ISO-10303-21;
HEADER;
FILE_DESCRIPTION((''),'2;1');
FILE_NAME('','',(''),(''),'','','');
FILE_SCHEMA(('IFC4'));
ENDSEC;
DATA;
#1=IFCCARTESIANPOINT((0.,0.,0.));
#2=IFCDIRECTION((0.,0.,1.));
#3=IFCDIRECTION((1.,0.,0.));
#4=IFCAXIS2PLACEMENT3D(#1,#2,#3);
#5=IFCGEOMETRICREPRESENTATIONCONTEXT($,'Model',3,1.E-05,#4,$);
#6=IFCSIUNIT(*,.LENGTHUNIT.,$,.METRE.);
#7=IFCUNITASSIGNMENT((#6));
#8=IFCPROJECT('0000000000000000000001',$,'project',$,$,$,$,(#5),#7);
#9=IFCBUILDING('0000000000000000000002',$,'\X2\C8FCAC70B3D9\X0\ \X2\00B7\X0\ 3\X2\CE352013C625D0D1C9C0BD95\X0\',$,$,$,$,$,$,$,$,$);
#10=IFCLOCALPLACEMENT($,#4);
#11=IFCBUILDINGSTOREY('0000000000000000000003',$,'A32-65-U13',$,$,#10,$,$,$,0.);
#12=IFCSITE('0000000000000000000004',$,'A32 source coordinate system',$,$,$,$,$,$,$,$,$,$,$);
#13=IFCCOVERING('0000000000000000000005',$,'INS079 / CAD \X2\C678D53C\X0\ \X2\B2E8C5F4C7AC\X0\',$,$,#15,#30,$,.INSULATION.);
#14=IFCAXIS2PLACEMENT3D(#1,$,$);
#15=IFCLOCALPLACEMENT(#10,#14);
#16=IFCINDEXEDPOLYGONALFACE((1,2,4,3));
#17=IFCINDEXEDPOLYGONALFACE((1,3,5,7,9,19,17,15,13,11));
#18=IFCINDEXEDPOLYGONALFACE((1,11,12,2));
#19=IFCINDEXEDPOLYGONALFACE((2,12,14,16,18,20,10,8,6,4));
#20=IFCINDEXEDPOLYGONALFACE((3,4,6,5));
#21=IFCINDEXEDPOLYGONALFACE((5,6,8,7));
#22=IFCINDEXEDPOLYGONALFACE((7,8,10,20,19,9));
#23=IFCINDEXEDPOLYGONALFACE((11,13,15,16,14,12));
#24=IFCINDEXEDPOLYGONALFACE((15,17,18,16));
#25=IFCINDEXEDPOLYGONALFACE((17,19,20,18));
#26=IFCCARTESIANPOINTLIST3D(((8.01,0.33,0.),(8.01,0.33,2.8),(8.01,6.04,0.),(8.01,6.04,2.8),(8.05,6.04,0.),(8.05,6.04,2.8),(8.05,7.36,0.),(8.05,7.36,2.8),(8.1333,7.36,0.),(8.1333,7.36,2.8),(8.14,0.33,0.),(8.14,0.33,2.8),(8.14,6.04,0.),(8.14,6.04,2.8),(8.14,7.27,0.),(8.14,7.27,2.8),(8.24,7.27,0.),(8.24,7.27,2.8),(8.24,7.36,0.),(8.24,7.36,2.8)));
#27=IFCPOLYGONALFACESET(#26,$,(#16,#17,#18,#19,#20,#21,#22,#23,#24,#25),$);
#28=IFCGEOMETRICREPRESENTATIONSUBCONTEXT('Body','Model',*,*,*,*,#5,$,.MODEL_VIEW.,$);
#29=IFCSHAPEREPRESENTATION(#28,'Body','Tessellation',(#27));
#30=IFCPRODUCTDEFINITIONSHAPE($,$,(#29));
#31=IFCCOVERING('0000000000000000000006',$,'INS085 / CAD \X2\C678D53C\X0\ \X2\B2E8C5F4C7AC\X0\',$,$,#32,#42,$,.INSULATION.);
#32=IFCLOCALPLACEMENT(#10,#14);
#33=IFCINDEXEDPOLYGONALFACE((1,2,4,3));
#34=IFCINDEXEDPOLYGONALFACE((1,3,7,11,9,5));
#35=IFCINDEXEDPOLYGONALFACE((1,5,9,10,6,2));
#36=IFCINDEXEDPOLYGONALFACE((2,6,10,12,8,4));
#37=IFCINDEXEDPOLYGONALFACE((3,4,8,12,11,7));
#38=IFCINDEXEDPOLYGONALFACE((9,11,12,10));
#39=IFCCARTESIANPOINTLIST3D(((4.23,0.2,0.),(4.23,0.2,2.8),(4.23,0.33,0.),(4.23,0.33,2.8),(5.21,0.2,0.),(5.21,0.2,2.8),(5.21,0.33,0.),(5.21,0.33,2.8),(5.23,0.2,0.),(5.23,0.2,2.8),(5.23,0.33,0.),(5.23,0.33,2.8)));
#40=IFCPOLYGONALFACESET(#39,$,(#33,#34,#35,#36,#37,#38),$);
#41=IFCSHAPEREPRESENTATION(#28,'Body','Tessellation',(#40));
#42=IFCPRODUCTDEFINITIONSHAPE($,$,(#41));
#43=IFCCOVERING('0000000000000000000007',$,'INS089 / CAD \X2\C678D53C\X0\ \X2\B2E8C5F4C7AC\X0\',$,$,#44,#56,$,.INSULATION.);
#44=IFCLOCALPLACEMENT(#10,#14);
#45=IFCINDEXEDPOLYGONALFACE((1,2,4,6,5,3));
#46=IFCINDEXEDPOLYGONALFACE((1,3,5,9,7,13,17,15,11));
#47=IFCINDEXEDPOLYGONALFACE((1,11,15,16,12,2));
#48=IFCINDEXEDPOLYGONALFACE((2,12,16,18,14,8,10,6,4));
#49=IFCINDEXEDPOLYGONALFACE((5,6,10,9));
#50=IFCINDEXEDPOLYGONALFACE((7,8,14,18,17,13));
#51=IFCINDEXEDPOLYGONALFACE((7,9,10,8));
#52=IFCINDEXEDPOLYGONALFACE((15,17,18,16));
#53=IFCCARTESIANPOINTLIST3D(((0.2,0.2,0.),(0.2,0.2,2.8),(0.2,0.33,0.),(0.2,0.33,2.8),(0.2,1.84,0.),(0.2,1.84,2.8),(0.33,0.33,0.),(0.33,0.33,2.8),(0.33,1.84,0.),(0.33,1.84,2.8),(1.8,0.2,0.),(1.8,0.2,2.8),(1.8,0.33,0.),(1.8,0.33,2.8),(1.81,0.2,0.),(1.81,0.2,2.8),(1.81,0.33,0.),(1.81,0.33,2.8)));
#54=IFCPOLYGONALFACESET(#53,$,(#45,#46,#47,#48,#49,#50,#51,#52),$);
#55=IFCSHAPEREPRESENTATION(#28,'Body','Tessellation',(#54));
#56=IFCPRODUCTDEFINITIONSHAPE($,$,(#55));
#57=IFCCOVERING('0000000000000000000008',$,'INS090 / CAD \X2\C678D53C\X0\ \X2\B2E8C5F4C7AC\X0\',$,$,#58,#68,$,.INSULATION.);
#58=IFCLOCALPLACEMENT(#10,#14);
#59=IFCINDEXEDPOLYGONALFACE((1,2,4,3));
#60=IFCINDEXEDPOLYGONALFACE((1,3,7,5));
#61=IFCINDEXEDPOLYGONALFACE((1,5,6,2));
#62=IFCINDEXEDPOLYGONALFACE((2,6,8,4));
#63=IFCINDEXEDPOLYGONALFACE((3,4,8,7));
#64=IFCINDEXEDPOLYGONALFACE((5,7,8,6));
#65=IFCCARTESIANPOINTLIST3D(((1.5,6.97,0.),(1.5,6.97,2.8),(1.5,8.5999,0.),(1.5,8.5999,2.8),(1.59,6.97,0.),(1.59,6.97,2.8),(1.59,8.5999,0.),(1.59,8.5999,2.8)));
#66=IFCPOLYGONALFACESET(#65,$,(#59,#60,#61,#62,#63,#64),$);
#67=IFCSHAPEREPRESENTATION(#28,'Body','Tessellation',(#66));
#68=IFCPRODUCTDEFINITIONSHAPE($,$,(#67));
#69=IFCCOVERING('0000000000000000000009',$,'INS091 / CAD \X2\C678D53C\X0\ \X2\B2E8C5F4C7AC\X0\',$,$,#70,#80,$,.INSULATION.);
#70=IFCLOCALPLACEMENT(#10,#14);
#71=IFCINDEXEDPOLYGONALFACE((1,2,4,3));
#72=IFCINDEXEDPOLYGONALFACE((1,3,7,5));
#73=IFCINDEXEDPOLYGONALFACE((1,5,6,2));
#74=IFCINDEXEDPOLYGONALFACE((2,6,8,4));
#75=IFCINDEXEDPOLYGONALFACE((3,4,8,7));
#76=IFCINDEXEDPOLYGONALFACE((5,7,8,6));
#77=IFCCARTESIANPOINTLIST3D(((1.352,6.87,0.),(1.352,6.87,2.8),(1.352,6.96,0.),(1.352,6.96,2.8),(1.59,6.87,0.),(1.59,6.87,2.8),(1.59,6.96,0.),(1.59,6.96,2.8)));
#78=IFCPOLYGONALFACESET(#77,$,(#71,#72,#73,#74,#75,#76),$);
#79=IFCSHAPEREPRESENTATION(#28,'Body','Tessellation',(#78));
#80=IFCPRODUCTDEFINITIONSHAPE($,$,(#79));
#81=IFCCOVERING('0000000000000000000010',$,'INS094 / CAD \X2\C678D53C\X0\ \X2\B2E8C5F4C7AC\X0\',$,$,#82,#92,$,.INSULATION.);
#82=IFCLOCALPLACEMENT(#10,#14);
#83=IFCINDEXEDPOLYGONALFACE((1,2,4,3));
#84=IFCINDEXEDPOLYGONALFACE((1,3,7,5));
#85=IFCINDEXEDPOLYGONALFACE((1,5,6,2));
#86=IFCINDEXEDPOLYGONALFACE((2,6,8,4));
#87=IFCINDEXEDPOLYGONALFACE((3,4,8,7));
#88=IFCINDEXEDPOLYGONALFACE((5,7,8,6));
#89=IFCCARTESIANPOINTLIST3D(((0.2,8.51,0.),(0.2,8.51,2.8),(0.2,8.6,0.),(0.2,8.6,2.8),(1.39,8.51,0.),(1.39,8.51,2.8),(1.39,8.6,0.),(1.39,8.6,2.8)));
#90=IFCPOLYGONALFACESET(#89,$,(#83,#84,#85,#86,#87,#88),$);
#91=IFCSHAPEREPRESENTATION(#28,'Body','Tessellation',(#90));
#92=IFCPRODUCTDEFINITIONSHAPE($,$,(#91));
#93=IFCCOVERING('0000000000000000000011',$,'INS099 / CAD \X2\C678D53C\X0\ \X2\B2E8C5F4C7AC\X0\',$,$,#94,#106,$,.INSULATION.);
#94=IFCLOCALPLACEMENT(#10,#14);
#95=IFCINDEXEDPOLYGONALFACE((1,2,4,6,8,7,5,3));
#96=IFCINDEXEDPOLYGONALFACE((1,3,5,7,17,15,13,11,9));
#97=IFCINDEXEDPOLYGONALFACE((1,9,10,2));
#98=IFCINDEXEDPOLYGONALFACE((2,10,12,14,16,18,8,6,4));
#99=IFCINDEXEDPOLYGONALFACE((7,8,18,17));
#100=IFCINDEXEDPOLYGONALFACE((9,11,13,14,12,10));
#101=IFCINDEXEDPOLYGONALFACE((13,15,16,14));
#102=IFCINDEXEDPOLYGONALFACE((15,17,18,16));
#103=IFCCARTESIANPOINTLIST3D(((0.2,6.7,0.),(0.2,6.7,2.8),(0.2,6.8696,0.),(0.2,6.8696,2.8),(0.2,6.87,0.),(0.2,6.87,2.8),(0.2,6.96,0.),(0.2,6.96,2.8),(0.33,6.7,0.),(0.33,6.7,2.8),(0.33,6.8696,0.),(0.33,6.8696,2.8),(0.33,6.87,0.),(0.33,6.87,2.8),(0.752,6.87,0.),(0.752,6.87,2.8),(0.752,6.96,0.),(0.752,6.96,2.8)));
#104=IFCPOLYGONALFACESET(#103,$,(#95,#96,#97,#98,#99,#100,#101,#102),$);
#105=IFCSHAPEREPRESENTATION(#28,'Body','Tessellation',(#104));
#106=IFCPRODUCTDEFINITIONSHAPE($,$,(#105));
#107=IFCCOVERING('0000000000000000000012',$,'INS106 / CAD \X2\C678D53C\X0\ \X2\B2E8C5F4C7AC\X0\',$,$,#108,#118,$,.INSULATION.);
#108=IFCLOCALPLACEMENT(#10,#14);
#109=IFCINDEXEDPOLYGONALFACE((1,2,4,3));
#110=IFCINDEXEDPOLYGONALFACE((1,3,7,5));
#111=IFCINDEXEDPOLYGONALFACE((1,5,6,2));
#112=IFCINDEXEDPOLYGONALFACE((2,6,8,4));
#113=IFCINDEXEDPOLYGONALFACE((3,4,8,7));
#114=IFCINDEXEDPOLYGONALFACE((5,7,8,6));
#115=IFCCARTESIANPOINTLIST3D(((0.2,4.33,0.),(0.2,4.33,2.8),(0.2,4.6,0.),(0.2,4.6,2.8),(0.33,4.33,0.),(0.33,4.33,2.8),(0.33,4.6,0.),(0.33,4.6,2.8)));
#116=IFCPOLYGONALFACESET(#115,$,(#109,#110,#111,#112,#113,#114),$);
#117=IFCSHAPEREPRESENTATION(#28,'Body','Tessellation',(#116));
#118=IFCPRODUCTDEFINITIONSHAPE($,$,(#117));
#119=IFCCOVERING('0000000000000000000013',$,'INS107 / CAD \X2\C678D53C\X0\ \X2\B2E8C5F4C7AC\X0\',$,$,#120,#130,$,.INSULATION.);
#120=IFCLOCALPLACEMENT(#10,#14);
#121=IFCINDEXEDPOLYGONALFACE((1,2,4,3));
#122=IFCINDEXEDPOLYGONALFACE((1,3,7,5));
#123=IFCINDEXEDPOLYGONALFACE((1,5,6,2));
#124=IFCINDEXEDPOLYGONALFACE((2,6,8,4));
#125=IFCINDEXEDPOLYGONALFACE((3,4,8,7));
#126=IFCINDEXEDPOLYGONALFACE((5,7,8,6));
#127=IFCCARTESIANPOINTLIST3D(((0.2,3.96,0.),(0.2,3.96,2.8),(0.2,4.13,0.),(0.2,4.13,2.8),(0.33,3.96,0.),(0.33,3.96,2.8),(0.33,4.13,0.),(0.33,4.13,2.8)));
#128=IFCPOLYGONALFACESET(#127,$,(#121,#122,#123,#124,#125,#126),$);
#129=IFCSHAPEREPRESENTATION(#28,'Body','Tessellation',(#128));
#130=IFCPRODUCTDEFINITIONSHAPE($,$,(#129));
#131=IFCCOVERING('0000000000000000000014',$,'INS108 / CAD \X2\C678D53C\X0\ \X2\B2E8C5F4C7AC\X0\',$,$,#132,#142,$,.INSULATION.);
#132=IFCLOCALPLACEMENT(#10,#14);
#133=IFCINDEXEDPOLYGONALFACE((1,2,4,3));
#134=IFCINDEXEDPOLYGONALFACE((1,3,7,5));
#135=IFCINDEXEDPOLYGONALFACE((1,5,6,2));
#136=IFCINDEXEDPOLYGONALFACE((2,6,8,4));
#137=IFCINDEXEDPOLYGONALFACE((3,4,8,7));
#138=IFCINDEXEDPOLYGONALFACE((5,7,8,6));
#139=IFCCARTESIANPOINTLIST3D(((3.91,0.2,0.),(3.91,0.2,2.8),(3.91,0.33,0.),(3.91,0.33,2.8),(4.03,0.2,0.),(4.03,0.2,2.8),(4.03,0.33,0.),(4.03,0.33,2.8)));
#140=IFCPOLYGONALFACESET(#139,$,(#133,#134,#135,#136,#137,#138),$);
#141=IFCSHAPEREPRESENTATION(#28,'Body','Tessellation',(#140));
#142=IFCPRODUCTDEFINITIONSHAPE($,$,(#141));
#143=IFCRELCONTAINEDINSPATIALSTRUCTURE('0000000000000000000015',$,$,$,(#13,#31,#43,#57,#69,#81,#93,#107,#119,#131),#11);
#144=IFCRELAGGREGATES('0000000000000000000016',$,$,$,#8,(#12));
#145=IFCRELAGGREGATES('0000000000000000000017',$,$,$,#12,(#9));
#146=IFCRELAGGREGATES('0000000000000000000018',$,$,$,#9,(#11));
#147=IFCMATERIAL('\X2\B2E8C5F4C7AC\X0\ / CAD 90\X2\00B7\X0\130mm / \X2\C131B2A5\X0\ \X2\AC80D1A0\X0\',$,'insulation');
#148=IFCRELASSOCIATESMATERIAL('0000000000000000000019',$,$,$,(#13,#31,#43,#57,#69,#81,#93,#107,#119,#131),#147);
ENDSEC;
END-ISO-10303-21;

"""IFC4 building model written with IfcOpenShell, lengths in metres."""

from ifc_helpers import new_model, si_unit, origin, origin_with_axes, place, context, subcontext, project, spatial, polyline, outline, extrude, material, element, save


model = new_model("IFC4")

# Units and contexts
model_context = context("Model", 3, precision=1e-05, world=origin_with_axes())
body_context = subcontext(model_context, "Body", "Model", "MODEL_VIEW")
ifc_project = project(units=[si_unit("LENGTHUNIT", "METRE")], contexts=[model_context])

# Site, building, storey
storey_placement = place(None, origin_with_axes())
site = spatial("IfcSite", under=ifc_project, Name="A32 source coordinate system")
building = spatial("IfcBuilding", under=site, Name="주거동 · 3층–옥탑지붕")
storey = spatial("IfcBuildingStorey", under=building, at=storey_placement, Name="A32-65-U13", Elevation=0.0)

# Coverings
ifc_material = material(Name="단열재 / CAD 90·130mm / 성능 검토", Category="insulation")
covering_1_placement = place(storey_placement, origin_with_axes())
element("IfcCovering", 1, at=covering_1_placement, inside=storey, material=ifc_material, Name="INS079 / CAD 외피 단열재", PredefinedType="INSULATION", context=body_context, shape_type="SweptSolid", body=[
    extrude(outline(polyline([(8.24, 7.27), (8.14, 7.27), (8.14, 6.04), (8.14, 0.33), (8.01, 0.33), (8.01, 6.04), (8.05, 6.04), (8.05, 7.36), (8.1333, 7.36), (8.24, 7.36), (8.24, 7.27)])), origin(), (0.0, 0.0, 1.0), 2.8),
])
covering_2_placement = place(storey_placement, origin_with_axes())
element("IfcCovering", 2, at=covering_2_placement, inside=storey, material=ifc_material, Name="INS085 / CAD 외피 단열재", PredefinedType="INSULATION", context=body_context, shape_type="SweptSolid", body=[
    extrude(outline(polyline([(4.23, 0.2), (4.23, 0.33), (5.21, 0.33), (5.23, 0.33), (5.23, 0.2), (5.21, 0.2), (4.23, 0.2)])), origin(), (0.0, 0.0, 1.0), 2.8),
])
covering_3_placement = place(storey_placement, origin_with_axes())
element("IfcCovering", 3, at=covering_3_placement, inside=storey, material=ifc_material, Name="INS089 / CAD 외피 단열재", PredefinedType="INSULATION", context=body_context, shape_type="SweptSolid", body=[
    extrude(outline(polyline([(0.2, 0.33), (0.2, 1.84), (0.33, 1.84), (0.33, 0.33), (1.8, 0.33), (1.81, 0.33), (1.81, 0.2), (1.8, 0.2), (0.2, 0.2), (0.2, 0.33)])), origin(), (0.0, 0.0, 1.0), 2.8),
])
covering_4_placement = place(storey_placement, origin_with_axes())
element("IfcCovering", 4, at=covering_4_placement, inside=storey, material=ifc_material, Name="INS090 / CAD 외피 단열재", PredefinedType="INSULATION", context=body_context, shape_type="SweptSolid", body=[
    extrude(outline(polyline([(1.59, 6.97), (1.5, 6.97), (1.5, 8.5999), (1.59, 8.5999), (1.59, 6.97)])), origin(), (0.0, 0.0, 1.0), 2.8),
])
covering_5_placement = place(storey_placement, origin_with_axes())
element("IfcCovering", 5, at=covering_5_placement, inside=storey, material=ifc_material, Name="INS091 / CAD 외피 단열재", PredefinedType="INSULATION", context=body_context, shape_type="SweptSolid", body=[
    extrude(outline(polyline([(1.59, 6.96), (1.59, 6.87), (1.352, 6.87), (1.352, 6.96), (1.59, 6.96)])), origin(), (0.0, 0.0, 1.0), 2.8),
])
covering_6_placement = place(storey_placement, origin_with_axes())
element("IfcCovering", 6, at=covering_6_placement, inside=storey, material=ifc_material, Name="INS094 / CAD 외피 단열재", PredefinedType="INSULATION", context=body_context, shape_type="SweptSolid", body=[
    extrude(outline(polyline([(1.39, 8.51), (0.2, 8.51), (0.2, 8.6), (1.39, 8.6), (1.39, 8.51)])), origin(), (0.0, 0.0, 1.0), 2.8),
])
covering_7_placement = place(storey_placement, origin_with_axes())
element("IfcCovering", 7, at=covering_7_placement, inside=storey, material=ifc_material, Name="INS099 / CAD 외피 단열재", PredefinedType="INSULATION", context=body_context, shape_type="SweptSolid", body=[
    extrude(outline(polyline([(0.2, 6.8696), (0.2, 6.87), (0.2, 6.96), (0.752, 6.96), (0.752, 6.87), (0.33, 6.87), (0.33, 6.8696), (0.33, 6.7), (0.2, 6.7), (0.2, 6.8696)])), origin(), (0.0, 0.0, 1.0), 2.8),
])
covering_8_placement = place(storey_placement, origin_with_axes())
element("IfcCovering", 8, at=covering_8_placement, inside=storey, material=ifc_material, Name="INS106 / CAD 외피 단열재", PredefinedType="INSULATION", context=body_context, shape_type="SweptSolid", body=[
    extrude(outline(polyline([(0.33, 4.6), (0.33, 4.33), (0.2, 4.33), (0.2, 4.6), (0.33, 4.6)])), origin(), (0.0, 0.0, 1.0), 2.8),
])
covering_9_placement = place(storey_placement, origin_with_axes())
element("IfcCovering", 9, at=covering_9_placement, inside=storey, material=ifc_material, Name="INS107 / CAD 외피 단열재", PredefinedType="INSULATION", context=body_context, shape_type="SweptSolid", body=[
    extrude(outline(polyline([(0.33, 3.96), (0.2, 3.96), (0.2, 4.13), (0.33, 4.13), (0.33, 3.96)])), origin(), (0.0, 0.0, 1.0), 2.8),
])
covering_10_placement = place(storey_placement, origin_with_axes())
element("IfcCovering", 10, at=covering_10_placement, inside=storey, material=ifc_material, Name="INS108 / CAD 외피 단열재", PredefinedType="INSULATION", context=body_context, shape_type="SweptSolid", body=[
    extrude(outline(polyline([(4.03, 0.2), (3.91, 0.2), (3.91, 0.33), (4.03, 0.33), (4.03, 0.2)])), origin(), (0.0, 0.0, 1.0), 2.8),
])

save(model, "model.ifc")
